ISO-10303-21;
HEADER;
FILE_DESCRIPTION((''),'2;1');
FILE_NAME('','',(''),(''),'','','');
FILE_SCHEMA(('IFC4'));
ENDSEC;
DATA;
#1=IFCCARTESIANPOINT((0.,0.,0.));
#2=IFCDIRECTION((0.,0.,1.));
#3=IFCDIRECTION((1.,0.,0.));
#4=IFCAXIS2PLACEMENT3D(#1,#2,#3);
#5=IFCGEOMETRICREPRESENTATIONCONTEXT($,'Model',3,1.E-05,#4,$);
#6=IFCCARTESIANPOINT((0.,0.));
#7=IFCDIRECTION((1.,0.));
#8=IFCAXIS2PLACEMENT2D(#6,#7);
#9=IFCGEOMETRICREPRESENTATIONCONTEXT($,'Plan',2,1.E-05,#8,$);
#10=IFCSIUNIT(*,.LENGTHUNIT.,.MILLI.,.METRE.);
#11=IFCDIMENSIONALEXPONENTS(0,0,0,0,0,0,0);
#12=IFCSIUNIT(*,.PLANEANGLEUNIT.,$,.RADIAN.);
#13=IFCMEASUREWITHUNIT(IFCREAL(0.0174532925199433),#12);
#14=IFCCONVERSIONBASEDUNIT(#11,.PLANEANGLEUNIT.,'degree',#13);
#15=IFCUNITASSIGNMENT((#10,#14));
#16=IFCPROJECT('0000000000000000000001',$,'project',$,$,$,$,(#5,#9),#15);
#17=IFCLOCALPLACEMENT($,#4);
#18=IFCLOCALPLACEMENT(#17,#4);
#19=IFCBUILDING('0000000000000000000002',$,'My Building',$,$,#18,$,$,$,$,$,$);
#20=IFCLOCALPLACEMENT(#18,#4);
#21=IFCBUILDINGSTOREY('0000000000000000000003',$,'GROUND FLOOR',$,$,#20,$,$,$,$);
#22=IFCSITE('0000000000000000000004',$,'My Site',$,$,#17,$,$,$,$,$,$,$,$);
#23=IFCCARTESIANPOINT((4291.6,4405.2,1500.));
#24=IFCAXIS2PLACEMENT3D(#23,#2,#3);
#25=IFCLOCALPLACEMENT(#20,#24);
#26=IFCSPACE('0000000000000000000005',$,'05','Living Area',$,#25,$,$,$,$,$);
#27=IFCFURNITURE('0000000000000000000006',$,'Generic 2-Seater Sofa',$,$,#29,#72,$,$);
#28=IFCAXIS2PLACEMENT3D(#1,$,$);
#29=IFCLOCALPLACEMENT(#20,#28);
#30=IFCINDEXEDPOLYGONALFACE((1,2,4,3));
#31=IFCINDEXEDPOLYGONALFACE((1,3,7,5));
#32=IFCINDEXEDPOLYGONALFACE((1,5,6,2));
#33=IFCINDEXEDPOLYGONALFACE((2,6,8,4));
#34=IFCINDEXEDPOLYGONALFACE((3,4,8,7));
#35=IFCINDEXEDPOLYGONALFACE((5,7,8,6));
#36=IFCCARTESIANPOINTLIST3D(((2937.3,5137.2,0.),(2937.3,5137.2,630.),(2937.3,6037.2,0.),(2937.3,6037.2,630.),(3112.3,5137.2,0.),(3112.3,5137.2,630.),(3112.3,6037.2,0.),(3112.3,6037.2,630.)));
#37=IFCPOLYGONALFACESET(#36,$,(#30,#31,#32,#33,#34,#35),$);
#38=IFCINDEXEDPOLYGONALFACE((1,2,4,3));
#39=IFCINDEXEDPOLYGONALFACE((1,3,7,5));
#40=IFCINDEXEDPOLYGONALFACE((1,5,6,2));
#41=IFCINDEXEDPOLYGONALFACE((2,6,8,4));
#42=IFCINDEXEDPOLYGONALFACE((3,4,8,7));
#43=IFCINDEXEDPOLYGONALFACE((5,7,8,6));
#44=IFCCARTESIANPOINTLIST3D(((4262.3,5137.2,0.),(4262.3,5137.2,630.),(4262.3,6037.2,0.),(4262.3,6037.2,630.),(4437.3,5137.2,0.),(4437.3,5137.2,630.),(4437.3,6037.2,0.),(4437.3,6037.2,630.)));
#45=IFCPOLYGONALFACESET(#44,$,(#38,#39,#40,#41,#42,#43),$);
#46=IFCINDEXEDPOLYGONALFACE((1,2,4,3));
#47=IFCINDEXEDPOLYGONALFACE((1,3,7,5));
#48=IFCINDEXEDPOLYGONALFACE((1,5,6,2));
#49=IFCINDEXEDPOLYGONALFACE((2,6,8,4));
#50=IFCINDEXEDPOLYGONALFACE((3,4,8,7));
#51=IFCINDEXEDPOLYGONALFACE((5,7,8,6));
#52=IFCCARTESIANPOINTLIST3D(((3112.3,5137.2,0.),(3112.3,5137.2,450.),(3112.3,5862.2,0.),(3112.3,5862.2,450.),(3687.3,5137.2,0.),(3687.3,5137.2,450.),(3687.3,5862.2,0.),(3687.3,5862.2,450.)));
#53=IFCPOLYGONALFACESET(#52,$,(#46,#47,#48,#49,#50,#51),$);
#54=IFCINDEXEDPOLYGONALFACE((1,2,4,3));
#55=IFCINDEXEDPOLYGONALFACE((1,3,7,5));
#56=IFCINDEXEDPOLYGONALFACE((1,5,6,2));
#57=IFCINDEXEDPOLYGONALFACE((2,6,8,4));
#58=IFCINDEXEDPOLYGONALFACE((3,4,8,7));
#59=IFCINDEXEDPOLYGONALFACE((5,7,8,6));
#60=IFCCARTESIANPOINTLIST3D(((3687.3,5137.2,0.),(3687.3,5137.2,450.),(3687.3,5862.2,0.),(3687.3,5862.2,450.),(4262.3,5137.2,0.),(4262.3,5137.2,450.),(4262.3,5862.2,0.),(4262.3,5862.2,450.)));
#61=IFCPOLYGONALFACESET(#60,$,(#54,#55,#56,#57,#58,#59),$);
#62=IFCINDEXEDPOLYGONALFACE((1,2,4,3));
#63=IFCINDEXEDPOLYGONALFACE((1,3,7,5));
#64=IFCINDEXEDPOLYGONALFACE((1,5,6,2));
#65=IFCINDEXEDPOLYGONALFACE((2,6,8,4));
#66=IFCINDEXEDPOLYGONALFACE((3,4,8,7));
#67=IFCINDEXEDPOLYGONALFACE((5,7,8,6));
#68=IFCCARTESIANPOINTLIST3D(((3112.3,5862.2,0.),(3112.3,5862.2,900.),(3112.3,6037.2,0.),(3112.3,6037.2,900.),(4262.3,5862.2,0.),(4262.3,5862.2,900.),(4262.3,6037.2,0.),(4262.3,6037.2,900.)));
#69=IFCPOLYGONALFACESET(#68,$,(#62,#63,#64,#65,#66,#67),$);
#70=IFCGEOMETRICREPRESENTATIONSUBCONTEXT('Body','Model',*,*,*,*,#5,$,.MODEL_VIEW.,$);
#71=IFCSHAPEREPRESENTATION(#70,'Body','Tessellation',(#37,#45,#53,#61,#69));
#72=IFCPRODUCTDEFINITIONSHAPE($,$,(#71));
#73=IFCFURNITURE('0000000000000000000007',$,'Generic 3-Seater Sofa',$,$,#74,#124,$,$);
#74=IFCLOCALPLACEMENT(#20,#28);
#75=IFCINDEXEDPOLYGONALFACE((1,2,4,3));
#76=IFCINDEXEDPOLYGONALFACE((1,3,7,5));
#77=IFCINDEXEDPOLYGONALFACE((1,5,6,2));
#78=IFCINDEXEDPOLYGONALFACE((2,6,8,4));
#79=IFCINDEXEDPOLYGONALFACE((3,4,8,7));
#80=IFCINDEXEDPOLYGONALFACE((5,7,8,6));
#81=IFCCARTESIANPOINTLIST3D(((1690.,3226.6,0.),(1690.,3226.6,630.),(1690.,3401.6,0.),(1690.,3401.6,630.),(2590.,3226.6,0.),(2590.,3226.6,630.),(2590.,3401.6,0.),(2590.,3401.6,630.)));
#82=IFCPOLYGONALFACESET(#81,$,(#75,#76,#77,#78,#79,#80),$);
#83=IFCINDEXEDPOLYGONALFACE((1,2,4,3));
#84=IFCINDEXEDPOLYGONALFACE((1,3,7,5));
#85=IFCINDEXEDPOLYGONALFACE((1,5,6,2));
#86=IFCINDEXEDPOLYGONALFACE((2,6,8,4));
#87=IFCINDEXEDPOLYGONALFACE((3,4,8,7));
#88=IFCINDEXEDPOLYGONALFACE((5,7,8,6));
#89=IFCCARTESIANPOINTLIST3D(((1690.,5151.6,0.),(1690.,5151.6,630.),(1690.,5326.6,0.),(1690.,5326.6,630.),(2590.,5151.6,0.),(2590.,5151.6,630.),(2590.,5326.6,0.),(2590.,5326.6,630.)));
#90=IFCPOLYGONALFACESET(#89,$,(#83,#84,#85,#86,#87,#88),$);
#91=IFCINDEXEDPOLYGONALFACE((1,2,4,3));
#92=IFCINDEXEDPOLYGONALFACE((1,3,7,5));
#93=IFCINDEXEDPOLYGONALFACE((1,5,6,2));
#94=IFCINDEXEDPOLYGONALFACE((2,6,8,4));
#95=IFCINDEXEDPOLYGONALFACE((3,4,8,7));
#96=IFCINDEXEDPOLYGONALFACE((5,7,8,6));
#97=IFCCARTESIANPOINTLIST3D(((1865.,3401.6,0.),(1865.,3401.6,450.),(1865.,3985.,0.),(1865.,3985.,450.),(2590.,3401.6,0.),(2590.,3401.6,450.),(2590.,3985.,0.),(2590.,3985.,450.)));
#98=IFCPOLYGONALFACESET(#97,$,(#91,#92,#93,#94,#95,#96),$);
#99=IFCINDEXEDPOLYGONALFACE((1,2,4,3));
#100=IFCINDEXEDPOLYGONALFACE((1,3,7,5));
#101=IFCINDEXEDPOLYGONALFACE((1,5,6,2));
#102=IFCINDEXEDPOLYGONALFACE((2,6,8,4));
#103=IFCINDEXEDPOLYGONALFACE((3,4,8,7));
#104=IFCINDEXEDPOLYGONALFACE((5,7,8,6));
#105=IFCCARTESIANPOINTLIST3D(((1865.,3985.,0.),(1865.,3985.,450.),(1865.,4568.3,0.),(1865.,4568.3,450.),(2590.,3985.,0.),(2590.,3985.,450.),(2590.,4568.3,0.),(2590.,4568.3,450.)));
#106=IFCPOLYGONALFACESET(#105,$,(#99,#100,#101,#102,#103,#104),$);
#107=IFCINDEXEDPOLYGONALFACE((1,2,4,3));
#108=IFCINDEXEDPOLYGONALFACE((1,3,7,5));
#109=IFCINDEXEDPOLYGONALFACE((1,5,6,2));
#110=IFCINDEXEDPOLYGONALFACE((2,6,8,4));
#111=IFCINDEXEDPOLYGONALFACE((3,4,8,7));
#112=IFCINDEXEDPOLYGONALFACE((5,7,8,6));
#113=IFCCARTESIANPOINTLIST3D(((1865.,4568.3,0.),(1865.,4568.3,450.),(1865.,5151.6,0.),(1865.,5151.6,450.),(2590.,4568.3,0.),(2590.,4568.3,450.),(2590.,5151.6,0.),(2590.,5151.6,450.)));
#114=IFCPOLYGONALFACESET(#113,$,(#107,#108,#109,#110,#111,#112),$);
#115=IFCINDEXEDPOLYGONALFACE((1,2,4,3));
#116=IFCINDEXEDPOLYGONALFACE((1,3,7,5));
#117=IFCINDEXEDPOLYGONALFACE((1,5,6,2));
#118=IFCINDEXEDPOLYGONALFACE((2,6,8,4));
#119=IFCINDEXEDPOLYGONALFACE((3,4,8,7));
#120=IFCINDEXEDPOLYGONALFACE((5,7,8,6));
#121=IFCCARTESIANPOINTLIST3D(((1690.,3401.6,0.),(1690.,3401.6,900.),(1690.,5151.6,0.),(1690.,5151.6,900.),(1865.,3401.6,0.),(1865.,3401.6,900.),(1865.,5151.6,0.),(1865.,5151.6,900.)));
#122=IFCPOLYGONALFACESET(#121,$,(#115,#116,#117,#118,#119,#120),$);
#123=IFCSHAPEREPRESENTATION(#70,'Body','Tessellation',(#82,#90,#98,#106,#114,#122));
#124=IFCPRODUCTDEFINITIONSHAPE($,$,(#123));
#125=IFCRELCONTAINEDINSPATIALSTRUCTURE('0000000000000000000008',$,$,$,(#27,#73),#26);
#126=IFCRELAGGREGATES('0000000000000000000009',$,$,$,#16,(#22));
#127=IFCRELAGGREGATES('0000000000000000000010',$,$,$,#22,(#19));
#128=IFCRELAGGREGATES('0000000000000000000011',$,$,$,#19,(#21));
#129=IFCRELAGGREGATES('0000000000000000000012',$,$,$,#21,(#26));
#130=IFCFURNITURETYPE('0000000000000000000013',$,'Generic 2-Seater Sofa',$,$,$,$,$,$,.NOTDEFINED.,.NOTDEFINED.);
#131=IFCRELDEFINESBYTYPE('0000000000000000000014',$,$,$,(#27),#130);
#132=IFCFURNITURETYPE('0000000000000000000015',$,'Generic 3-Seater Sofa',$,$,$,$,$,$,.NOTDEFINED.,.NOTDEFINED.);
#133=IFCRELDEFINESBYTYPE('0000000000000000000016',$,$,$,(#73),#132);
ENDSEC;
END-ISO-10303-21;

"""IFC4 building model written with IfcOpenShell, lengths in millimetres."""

from ifc_helpers import new_model, entity, si_unit, converted_unit, frame, origin_with_axes, origin_2d_with_axis, place, context, subcontext, project, spatial, line, indexed_curve, outline, extrude, shape, source, transform, mapped, type_object, type_shapes, element, save


model = new_model("IFC4")

# Units and contexts
model_context = context("Model", 3, precision=1e-05, world=origin_with_axes())
plan_context = context("Plan", 2, precision=1e-05, world=origin_2d_with_axis())
body_context_1 = subcontext(model_context, "Body", "Model", "MODEL_VIEW")
body_context_2 = subcontext(plan_context, "Body", "Plan", "PLAN_VIEW")
ifc_project = project(units=[si_unit("LENGTHUNIT", "METRE", prefix="MILLI"), converted_unit("PLANEANGLEUNIT", "degree", entity("IfcReal", 0.0174532925199433), si_unit("PLANEANGLEUNIT", "RADIAN"), dimensions=[0, 0, 0, 0, 0, 0, 0])], contexts=[model_context, plan_context])

# Site, building, storey
site_placement = place(None, origin_with_axes())
site = spatial("IfcSite", under=ifc_project, at=site_placement, Name="My Site")
building_placement = place(site_placement, origin_with_axes())
building = spatial("IfcBuilding", under=site, at=building_placement, Name="My Building")
storey_placement = place(building_placement, origin_with_axes())
storey = spatial("IfcBuildingStorey", under=building, at=storey_placement, Name="GROUND FLOOR")

# Shared definitions
space_1_placement = place(storey_placement, frame((4291.6, 4405.2, 1500.0), z_axis=(0.0, 0.0, 1.0), x_axis=(1.0, 0.0, 0.0)))
space_1 = spatial("IfcSpace", under=storey, at=space_1_placement, Name="05", Description="Living Area")

# Furniture
furniture_type_1 = type_object("IfcFurnitureType", Name="Generic 2-Seater Sofa", AssemblyPlace="NOTDEFINED", PredefinedType="NOTDEFINED")
shared_shape_1 = source(origin_with_axes(), body_context_1, "Body", "SweptSolid", [
    extrude(outline(indexed_curve([(0.0, 0.0), (175.0, 0.0), (175.0, 900.0), (0.0, 900.0)], segments=[line(1, 2, 3, 4, 1)])), frame((-750.0, -900.0, 0.0), z_axis=(0.0, 0.0, 1.0), x_axis=(1.0, 0.0, 0.0)), (0.0, 0.0, 1.0), 630.0),
    extrude(outline(indexed_curve([(0.0, 0.0), (175.0, 0.0), (175.0, 900.0), (0.0, 900.0)], segments=[line(1, 2, 3, 4, 1)])), frame((575.0, -900.0, 0.0), z_axis=(0.0, 0.0, 1.0), x_axis=(1.0, 0.0, 0.0)), (0.0, 0.0, 1.0), 630.0),
    extrude(outline(indexed_curve([(175.0, 0.0), (750.0, 0.0), (750.0, 725.0), (175.0, 725.0)], segments=[line(1, 2, 3, 4, 1)])), frame((-750.0, -900.0, 0.0), z_axis=(0.0, 0.0, 1.0), x_axis=(1.0, 0.0, 0.0)), (0.0, 0.0, 1.0), 450.0),
    extrude(outline(indexed_curve([(750.0, 0.0), (1325.0, 0.0), (1325.0, 725.0), (750.0, 725.0)], segments=[line(1, 2, 3, 4, 1)])), frame((-750.0, -900.0, 0.0), z_axis=(0.0, 0.0, 1.0), x_axis=(1.0, 0.0, 0.0)), (0.0, 0.0, 1.0), 450.0),
    extrude(outline(indexed_curve([(175.0, 725.0), (1325.0, 725.0), (1325.0, 900.0), (175.0, 900.0)], segments=[line(1, 2, 3, 4, 1)])), frame((-750.0, -900.0, 0.0), z_axis=(0.0, 0.0, 1.0), x_axis=(1.0, 0.0, 0.0)), (0.0, 0.0, 1.0), 900.0),
])
shared_shape_2 = source(origin_with_axes(), body_context_2, "Body", "Curve2D", [
    entity("IfcIndexedPolyCurve", entity("IfcCartesianPointList2D", [[-750.0, -900.0], [-575.0, -900.0], [-575.0, 0.0], [-750.0, 0.0]]), [entity("IfcLineIndex", [1, 2, 3, 4, 1])]),
    entity("IfcIndexedPolyCurve", entity("IfcCartesianPointList2D", [[575.0, -900.0], [750.0, -900.0], [750.0, 0.0], [575.0, 0.0]]), [entity("IfcLineIndex", [1, 2, 3, 4, 1])]),
    entity("IfcIndexedPolyCurve", entity("IfcCartesianPointList2D", [[-575.0, -900.0], [0.0, -900.0], [0.0, -175.0], [-575.0, -175.0]]), [entity("IfcLineIndex", [1, 2, 3, 4, 1])]),
    entity("IfcIndexedPolyCurve", entity("IfcCartesianPointList2D", [[0.0, -900.0], [575.0, -900.0], [575.0, -175.0], [0.0, -175.0]]), [entity("IfcLineIndex", [1, 2, 3, 4, 1])]),
    entity("IfcIndexedPolyCurve", entity("IfcCartesianPointList2D", [[-575.0, -175.0], [575.0, -175.0], [575.0, 0.0], [-575.0, 0.0]]), [entity("IfcLineIndex", [1, 2, 3, 4, 1])]),
])
type_shapes(furniture_type_1, [shared_shape_1, shared_shape_2])
furniture_1_placement = place(space_1_placement, frame((-604.4, 1632.0, -1500.0), z_axis=(0.0, 0.0, 1.0), x_axis=(1.0, 0.0, 0.0)))
element("IfcFurniture", 1, at=furniture_1_placement, inside=space_1, type_object=furniture_type_1, Name="Generic 2-Seater Sofa", shapes=[
    shape(body_context_1, "Body", "MappedRepresentation", [mapped(shared_shape_1, transform((0.0, 0.0, 0.0), x_axis=(1.0, 0.0, 0.0), y_axis=(0.0, 1.0, 0.0), z_axis=(0.0, 0.0, 1.0), scale=1.0))]),
    shape(body_context_2, "Body", "MappedRepresentation", [mapped(shared_shape_2, transform((0.0, 0.0, 0.0), x_axis=(1.0, 0.0, 0.0), y_axis=(0.0, 1.0, 0.0), z_axis=(0.0, 0.0, 1.0), scale=1.0))]),
])
furniture_type_2 = type_object("IfcFurnitureType", Name="Generic 3-Seater Sofa", AssemblyPlace="NOTDEFINED", PredefinedType="NOTDEFINED")
shared_shape_3 = source(origin_with_axes(), body_context_1, "Body", "SweptSolid", [
    extrude(outline(indexed_curve([(0.0, 0.0), (175.0, 0.0), (175.0, 900.0), (0.0, 900.0)], segments=[line(1, 2, 3, 4, 1)])), frame((-1050.0, -900.0, 0.0), z_axis=(0.0, 0.0, 1.0), x_axis=(1.0, 0.0, 0.0)), (0.0, 0.0, 1.0), 630.0),
    extrude(outline(indexed_curve([(0.0, 0.0), (175.0, 0.0), (175.0, 900.0), (0.0, 900.0)], segments=[line(1, 2, 3, 4, 1)])), frame((875.0, -900.0, 0.0), z_axis=(0.0, 0.0, 1.0), x_axis=(1.0, 0.0, 0.0)), (0.0, 0.0, 1.0), 630.0),
    extrude(outline(indexed_curve([(175.0, 0.0), (758.3, 0.0), (758.3, 725.0), (175.0, 725.0)], segments=[line(1, 2, 3, 4, 1)])), frame((-1050.0, -900.0, 0.0), z_axis=(0.0, 0.0, 1.0), x_axis=(1.0, 0.0, 0.0)), (0.0, 0.0, 1.0), 450.0),
    extrude(outline(indexed_curve([(758.3, 0.0), (1341.7, 0.0), (1341.7, 725.0), (758.3, 725.0)], segments=[line(1, 2, 3, 4, 1)])), frame((-1050.0, -900.0, 0.0), z_axis=(0.0, 0.0, 1.0), x_axis=(1.0, 0.0, 0.0)), (0.0, 0.0, 1.0), 450.0),
    extrude(outline(indexed_curve([(1341.7, 0.0), (1925.0, 0.0), (1925.0, 725.0), (1341.7, 725.0)], segments=[line(1, 2, 3, 4, 1)])), frame((-1050.0, -900.0, 0.0), z_axis=(0.0, 0.0, 1.0), x_axis=(1.0, 0.0, 0.0)), (0.0, 0.0, 1.0), 450.0),
    extrude(outline(indexed_curve([(175.0, 725.0), (1925.0, 725.0), (1925.0, 900.0), (175.0, 900.0)], segments=[line(1, 2, 3, 4, 1)])), frame((-1050.0, -900.0, 0.0), z_axis=(0.0, 0.0, 1.0), x_axis=(1.0, 0.0, 0.0)), (0.0, 0.0, 1.0), 900.0),
])
shared_shape_4 = source(origin_with_axes(), body_context_2, "Body", "Curve2D", [
    entity("IfcIndexedPolyCurve", entity("IfcCartesianPointList2D", [[-1050.0, -900.0], [-875.0, -900.0], [-875.0, 0.0], [-1050.0, 0.0]]), [entity("IfcLineIndex", [1, 2, 3, 4, 1])]),
    entity("IfcIndexedPolyCurve", entity("IfcCartesianPointList2D", [[875.0, -900.0], [1050.0, -900.0], [1050.0, 0.0], [875.0, 0.0]]), [entity("IfcLineIndex", [1, 2, 3, 4, 1])]),
    entity("IfcIndexedPolyCurve", entity("IfcCartesianPointList2D", [[-875.0, -900.0], [-291.7, -900.0], [-291.7, -175.0], [-875.0, -175.0]]), [entity("IfcLineIndex", [1, 2, 3, 4, 1])]),
    entity("IfcIndexedPolyCurve", entity("IfcCartesianPointList2D", [[-291.7, -900.0], [291.7, -900.0], [291.7, -175.0], [-291.7, -175.0]]), [entity("IfcLineIndex", [1, 2, 3, 4, 1])]),
    entity("IfcIndexedPolyCurve", entity("IfcCartesianPointList2D", [[291.7, -900.0], [875.0, -900.0], [875.0, -175.0], [291.7, -175.0]]), [entity("IfcLineIndex", [1, 2, 3, 4, 1])]),
    entity("IfcIndexedPolyCurve", entity("IfcCartesianPointList2D", [[-875.0, -175.0], [875.0, -175.0], [875.0, 0.0], [-875.0, 0.0]]), [entity("IfcLineIndex", [1, 2, 3, 4, 1])]),
])
type_shapes(furniture_type_2, [shared_shape_3, shared_shape_4])
furniture_2_placement = place(space_1_placement, frame((-2601.6, -128.5, -1500.0), z_axis=(0.0, 0.0, 1.0), x_axis=(0.0, 1.0, 0.0)))
element("IfcFurniture", 2, at=furniture_2_placement, inside=space_1, type_object=furniture_type_2, Name="Generic 3-Seater Sofa", shapes=[
    shape(body_context_1, "Body", "MappedRepresentation", [mapped(shared_shape_3, transform((0.0, 0.0, 0.0), x_axis=(1.0, 0.0, 0.0), y_axis=(0.0, 1.0, 0.0), z_axis=(0.0, 0.0, 1.0), scale=1.0))]),
    shape(body_context_2, "Body", "MappedRepresentation", [mapped(shared_shape_4, transform((0.0, 0.0, 0.0), x_axis=(1.0, 0.0, 0.0), y_axis=(0.0, 1.0, 0.0), z_axis=(0.0, 0.0, 1.0), scale=1.0))]),
])

save(model, "model.ifc")
